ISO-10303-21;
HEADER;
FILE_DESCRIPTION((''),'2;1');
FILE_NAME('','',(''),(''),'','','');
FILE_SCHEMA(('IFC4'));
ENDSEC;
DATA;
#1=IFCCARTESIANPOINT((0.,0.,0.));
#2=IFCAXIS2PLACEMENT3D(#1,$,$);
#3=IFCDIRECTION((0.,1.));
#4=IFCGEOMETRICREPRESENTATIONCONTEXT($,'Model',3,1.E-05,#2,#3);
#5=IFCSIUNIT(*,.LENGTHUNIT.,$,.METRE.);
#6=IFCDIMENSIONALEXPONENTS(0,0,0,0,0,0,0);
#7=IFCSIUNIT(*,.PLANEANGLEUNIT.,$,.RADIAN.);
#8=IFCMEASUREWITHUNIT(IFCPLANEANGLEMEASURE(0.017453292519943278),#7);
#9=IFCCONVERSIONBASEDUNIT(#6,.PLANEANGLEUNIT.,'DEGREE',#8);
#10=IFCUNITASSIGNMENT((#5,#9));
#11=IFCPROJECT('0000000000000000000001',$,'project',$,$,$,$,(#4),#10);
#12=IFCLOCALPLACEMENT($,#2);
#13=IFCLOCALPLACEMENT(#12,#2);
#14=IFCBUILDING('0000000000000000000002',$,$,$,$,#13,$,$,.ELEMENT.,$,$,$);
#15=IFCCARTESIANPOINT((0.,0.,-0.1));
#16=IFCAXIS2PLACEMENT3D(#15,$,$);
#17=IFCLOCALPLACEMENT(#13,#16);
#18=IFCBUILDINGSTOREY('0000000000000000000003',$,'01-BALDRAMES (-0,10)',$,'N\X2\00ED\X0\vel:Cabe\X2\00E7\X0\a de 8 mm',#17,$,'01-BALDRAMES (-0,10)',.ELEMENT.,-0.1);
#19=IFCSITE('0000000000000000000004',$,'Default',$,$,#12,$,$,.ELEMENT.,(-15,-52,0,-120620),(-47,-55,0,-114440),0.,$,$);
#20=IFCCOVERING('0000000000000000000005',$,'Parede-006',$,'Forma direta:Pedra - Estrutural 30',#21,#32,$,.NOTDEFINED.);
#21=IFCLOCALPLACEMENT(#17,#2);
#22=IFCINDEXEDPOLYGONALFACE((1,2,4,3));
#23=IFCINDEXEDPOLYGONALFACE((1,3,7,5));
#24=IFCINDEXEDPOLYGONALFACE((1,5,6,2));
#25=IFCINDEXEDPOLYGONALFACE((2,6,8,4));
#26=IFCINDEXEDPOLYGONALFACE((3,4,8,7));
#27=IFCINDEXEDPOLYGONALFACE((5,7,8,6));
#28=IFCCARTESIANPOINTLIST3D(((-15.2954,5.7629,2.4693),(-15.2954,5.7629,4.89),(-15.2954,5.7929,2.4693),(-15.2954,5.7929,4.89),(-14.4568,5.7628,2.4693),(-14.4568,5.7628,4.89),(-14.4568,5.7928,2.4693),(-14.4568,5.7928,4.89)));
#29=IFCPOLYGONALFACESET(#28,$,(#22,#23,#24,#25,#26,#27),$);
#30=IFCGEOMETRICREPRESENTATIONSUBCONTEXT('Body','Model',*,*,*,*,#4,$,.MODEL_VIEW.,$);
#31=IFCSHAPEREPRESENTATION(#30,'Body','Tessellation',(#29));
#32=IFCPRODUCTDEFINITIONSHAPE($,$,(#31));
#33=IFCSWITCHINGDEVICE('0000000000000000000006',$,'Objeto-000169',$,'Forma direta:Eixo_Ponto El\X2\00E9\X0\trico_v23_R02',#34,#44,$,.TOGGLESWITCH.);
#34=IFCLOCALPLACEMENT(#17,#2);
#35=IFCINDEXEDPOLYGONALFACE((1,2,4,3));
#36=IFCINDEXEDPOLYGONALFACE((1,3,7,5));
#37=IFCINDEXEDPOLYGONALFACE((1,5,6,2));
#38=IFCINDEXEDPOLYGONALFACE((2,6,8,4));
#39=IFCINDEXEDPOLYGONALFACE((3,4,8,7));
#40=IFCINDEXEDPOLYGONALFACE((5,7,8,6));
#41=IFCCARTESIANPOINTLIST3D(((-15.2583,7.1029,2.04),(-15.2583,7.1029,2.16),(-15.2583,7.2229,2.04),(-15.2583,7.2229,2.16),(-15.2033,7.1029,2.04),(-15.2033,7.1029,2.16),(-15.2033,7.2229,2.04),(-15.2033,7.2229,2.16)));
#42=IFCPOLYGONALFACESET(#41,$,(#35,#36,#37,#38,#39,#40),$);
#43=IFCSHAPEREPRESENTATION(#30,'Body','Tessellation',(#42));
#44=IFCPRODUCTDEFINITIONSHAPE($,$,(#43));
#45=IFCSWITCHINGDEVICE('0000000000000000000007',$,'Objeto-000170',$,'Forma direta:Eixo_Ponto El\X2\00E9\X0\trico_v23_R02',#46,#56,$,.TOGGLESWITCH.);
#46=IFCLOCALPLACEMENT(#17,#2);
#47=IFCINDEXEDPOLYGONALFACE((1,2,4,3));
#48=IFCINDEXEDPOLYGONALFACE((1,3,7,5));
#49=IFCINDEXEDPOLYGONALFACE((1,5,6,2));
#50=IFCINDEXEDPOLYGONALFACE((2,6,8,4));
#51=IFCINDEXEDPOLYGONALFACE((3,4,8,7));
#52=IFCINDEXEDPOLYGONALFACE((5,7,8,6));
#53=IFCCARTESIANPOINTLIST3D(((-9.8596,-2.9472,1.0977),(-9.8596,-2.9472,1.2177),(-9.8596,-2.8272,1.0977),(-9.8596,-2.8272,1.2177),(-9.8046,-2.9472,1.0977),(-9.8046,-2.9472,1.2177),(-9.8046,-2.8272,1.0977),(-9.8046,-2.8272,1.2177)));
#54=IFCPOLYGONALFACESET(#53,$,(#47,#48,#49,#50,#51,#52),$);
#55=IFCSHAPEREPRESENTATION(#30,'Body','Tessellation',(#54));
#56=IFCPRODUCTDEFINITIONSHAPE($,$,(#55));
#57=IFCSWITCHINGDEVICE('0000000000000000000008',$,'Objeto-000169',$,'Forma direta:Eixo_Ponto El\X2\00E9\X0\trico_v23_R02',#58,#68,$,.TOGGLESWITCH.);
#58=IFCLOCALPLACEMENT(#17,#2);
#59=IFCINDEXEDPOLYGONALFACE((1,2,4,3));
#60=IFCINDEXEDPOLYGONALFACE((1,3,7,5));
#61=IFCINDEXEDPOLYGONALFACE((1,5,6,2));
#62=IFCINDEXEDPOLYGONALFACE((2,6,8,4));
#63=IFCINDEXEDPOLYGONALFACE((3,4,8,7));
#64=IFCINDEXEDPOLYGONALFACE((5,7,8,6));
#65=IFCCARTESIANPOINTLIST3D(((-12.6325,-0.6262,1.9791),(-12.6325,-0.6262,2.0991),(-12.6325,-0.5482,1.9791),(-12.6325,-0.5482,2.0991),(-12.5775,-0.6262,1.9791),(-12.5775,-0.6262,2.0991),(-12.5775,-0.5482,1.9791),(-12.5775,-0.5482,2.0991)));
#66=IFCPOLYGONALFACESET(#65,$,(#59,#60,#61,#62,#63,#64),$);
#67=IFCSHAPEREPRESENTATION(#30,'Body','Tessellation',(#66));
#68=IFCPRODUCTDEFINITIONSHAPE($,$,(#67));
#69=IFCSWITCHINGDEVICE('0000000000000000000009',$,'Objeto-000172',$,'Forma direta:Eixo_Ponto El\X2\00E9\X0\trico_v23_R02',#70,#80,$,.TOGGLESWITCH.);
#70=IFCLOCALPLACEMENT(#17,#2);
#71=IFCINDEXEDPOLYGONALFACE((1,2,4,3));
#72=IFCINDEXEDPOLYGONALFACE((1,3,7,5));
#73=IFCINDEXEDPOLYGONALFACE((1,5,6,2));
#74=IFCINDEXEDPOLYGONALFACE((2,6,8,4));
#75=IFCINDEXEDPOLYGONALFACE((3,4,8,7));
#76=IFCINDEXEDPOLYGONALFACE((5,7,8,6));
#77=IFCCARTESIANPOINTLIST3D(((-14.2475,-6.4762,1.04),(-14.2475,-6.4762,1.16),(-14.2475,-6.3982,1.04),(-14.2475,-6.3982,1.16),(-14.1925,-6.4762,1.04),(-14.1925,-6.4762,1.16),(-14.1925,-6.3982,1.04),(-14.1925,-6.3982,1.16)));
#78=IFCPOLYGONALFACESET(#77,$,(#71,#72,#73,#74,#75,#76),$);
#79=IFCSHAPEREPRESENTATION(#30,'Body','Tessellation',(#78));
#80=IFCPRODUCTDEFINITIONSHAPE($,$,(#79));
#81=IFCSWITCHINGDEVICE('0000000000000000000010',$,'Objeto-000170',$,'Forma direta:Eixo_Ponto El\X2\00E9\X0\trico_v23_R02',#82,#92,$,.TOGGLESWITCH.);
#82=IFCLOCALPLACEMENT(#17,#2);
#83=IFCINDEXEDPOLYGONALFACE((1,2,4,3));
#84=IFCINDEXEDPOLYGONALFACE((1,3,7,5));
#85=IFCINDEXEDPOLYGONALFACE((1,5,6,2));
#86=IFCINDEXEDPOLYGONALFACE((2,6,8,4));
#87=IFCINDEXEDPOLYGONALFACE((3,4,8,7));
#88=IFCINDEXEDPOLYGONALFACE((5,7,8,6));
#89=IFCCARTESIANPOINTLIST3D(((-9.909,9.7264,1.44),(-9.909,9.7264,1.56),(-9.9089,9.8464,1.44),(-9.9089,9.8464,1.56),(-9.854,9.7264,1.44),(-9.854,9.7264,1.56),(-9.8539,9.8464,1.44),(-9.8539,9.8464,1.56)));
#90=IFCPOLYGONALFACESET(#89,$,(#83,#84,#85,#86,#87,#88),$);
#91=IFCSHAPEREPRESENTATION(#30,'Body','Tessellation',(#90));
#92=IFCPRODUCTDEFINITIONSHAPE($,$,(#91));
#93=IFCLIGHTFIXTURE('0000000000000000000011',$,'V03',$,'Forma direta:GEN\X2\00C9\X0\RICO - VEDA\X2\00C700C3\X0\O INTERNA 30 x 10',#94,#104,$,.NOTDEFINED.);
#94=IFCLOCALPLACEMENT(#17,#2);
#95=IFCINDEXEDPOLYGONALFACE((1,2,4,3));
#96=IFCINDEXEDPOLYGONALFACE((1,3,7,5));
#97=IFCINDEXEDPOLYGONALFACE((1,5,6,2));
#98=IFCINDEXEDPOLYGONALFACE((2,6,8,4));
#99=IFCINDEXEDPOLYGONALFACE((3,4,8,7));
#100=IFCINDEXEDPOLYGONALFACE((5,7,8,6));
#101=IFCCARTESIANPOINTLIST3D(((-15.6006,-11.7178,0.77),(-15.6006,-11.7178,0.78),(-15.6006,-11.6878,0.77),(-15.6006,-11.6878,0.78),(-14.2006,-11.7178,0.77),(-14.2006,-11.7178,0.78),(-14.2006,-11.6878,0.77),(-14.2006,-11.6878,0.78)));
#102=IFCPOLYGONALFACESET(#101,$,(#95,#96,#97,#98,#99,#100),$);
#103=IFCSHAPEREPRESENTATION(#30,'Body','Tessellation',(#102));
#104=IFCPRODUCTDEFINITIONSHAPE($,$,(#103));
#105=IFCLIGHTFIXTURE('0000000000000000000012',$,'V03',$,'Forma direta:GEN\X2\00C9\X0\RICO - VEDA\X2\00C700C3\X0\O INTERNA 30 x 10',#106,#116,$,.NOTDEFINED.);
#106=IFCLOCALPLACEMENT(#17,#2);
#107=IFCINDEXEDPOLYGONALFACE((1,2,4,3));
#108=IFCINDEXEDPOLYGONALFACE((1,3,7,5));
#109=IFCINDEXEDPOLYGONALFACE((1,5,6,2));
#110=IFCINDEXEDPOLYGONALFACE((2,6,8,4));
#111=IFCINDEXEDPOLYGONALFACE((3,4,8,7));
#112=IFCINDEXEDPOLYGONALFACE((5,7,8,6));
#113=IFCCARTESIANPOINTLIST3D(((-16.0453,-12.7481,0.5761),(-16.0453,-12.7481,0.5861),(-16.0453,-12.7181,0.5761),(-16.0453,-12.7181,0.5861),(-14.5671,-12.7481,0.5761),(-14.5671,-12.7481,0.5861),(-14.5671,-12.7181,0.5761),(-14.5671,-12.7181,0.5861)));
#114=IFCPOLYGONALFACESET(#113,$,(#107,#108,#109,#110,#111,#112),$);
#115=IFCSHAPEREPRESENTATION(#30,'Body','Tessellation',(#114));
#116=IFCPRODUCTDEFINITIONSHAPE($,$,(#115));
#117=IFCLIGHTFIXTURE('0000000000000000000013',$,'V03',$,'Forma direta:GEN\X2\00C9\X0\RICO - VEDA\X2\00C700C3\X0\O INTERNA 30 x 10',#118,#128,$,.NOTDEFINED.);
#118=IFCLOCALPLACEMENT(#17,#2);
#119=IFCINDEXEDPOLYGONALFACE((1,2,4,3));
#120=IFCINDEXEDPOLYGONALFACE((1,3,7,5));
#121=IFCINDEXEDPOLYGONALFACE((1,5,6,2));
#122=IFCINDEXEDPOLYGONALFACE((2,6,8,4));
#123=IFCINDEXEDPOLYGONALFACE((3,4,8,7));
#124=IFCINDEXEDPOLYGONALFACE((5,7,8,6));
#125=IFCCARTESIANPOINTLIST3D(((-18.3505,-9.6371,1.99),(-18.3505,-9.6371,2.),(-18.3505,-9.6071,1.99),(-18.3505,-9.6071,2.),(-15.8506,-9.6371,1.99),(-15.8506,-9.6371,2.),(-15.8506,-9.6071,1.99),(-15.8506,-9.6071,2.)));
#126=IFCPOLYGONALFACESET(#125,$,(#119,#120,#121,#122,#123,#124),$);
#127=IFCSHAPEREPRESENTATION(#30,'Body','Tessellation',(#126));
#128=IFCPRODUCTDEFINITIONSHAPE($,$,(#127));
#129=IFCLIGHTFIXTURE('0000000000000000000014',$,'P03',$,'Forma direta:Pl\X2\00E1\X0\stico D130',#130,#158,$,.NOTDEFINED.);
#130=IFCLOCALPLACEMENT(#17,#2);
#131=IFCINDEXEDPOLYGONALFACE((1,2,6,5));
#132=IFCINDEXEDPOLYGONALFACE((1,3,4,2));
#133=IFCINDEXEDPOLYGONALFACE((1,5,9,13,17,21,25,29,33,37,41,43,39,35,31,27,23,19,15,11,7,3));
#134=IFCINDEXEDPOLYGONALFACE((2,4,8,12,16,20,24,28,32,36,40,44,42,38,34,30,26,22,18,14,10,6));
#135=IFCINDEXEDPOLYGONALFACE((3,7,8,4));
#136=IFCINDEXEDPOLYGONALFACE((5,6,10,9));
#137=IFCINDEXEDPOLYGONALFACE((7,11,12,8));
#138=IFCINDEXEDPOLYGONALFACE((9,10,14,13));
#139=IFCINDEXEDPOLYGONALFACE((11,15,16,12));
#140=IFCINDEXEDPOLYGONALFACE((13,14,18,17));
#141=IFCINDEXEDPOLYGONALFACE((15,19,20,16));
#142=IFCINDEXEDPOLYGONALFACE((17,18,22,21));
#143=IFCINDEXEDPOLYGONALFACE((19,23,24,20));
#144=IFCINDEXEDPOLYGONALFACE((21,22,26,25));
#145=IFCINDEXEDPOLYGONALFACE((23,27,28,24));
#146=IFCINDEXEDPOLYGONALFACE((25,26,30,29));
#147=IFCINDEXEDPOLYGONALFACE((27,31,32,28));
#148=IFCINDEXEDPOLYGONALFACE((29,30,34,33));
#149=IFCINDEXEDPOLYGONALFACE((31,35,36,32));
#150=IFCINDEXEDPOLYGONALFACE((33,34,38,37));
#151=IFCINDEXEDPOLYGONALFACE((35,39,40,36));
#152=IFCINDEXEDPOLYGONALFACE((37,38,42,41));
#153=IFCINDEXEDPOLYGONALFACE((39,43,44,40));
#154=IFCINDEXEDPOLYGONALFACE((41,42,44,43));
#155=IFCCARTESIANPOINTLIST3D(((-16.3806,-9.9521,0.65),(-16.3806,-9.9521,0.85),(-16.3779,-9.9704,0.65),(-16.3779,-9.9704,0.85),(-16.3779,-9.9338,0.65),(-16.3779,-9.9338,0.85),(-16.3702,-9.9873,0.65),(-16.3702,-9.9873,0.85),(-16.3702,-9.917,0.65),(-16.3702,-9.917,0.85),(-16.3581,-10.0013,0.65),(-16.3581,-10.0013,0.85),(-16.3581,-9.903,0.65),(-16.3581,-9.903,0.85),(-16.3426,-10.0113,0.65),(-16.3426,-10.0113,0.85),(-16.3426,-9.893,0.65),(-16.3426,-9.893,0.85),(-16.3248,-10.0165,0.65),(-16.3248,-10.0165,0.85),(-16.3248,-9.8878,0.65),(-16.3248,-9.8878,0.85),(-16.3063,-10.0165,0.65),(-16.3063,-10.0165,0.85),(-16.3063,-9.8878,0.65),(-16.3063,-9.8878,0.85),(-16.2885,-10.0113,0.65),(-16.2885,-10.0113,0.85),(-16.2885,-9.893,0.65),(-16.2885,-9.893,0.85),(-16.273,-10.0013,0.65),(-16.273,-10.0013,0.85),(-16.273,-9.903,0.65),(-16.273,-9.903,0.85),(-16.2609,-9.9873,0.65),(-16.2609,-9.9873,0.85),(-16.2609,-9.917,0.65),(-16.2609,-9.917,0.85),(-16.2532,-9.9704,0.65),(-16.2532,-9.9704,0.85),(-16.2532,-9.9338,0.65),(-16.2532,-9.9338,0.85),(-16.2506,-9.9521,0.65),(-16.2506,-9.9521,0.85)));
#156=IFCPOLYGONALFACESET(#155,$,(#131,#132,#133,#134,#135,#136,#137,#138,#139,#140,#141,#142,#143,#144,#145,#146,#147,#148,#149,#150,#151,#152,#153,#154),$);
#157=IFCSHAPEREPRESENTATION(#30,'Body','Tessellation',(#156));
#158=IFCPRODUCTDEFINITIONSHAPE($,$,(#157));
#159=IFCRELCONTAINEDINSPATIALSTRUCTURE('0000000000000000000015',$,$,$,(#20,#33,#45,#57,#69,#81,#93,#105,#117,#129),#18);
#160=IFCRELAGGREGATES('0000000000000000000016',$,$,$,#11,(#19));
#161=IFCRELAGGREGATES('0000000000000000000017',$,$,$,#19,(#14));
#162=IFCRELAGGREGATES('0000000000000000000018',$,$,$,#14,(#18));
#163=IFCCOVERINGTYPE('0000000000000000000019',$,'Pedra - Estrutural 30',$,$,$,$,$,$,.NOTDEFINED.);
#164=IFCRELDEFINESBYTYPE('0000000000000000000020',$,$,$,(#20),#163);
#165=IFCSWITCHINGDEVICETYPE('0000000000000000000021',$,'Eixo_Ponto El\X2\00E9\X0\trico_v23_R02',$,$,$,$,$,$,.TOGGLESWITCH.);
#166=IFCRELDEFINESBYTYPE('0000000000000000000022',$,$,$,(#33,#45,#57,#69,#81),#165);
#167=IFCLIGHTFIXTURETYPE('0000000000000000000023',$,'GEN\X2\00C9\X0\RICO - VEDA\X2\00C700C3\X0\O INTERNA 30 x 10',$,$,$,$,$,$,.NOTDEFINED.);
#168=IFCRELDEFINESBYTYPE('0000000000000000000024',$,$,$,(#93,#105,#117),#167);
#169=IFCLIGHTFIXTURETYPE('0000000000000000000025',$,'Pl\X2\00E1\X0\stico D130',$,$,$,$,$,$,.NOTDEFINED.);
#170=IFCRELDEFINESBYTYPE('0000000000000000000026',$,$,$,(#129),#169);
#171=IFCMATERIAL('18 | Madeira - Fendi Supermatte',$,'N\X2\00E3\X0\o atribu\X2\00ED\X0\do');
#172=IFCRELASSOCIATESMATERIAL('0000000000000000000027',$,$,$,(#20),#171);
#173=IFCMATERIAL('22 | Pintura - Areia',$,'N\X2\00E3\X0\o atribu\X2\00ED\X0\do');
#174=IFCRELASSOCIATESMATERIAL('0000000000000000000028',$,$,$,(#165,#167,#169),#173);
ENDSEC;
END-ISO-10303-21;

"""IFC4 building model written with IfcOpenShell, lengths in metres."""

from ifc_helpers import new_model, entity, si_unit, converted_unit, direction, frame, origin, place, context, subcontext, project, spatial, arc, indexed_curve, outline, extrude, material, type_object, element, save


model = new_model("IFC4")

# Units and contexts
model_context = context("Model", 3, precision=1e-05, world=origin(), true_north=direction((0.0, 1.0)))
body_context = subcontext(model_context, "Body", "Model", "MODEL_VIEW")
ifc_project = project(units=[si_unit("LENGTHUNIT", "METRE"), converted_unit("PLANEANGLEUNIT", "DEGREE", entity("IfcPlaneAngleMeasure", 0.017453292519943278), si_unit("PLANEANGLEUNIT", "RADIAN"), dimensions=[0, 0, 0, 0, 0, 0, 0])], contexts=[model_context])

# Site, building, storey
site_placement = place(None, origin())
site = spatial("IfcSite", under=ifc_project, at=site_placement, Name="Default", CompositionType="ELEMENT", RefLatitude=(-15, -52, 0, -120620), RefLongitude=(-47, -55, 0, -114440), RefElevation=0.0)
building_placement = place(site_placement, origin())
building = spatial("IfcBuilding", under=site, at=building_placement, CompositionType="ELEMENT")
storey_placement = place(building_placement, frame((0.0, 0.0, -0.1)))
storey = spatial("IfcBuildingStorey", under=building, at=storey_placement, Name="01-BALDRAMES (-0,10)", ObjectType="Nível:Cabeça de 8 mm", LongName="01-BALDRAMES (-0,10)", CompositionType="ELEMENT", Elevation=-0.1)

# Covering
ifc_material_1 = material(Name="18 | Madeira - Fendi Supermatte", Category="Não atribuído")
covering_type = type_object("IfcCoveringType", Name="Pedra - Estrutural 30", PredefinedType="NOTDEFINED")
covering_placement = place(storey_placement, origin())
element("IfcCovering", 1, at=covering_placement, inside=storey, type_object=covering_type, material=ifc_material_1, Name="Parede-006", ObjectType="Forma direta:Pedra - Estrutural 30", PredefinedType="NOTDEFINED", context=body_context, shape_type="SweptSolid", body=[
    extrude(outline(indexed_curve([(-0.015, -0.4193), (0.015, -0.4193), (0.015, 0.4193), (-0.015, 0.4193), (-0.015, -0.4193)], self_intersect=False)), frame((-14.8761, 5.7778, 2.4693), z_axis=(0.0, 0.0, 1.0), x_axis=(0.000013, 1.0, 0.0)), (0.0, 0.0, 1.0), 2.4207),
])

# Switching devices
ifc_material_2 = material(Name="22 | Pintura - Areia", Category="Não atribuído")
switching_device_type = type_object("IfcSwitchingDeviceType", Name="Eixo_Ponto Elétrico_v23_R02", PredefinedType="TOGGLESWITCH", material=ifc_material_2)
switching_device_1_placement = place(storey_placement, origin())
element("IfcSwitchingDevice", 2, at=switching_device_1_placement, inside=storey, type_object=switching_device_type, Name="Objeto-000169", ObjectType="Forma direta:Eixo_Ponto Elétrico_v23_R02", PredefinedType="TOGGLESWITCH", context=body_context, shape_type="SweptSolid", body=[
    extrude(outline(indexed_curve([(-0.0275, -0.06), (0.0275, -0.06), (0.0275, 0.06), (-0.0275, 0.06), (-0.0275, -0.06)], self_intersect=False)), frame((-15.2308, 7.1629, 2.04)), (0.0, 0.0, 1.0), 0.12),
])
switching_device_2_placement = place(storey_placement, origin())
element("IfcSwitchingDevice", 3, at=switching_device_2_placement, inside=storey, type_object=switching_device_type, Name="Objeto-000170", ObjectType="Forma direta:Eixo_Ponto Elétrico_v23_R02", PredefinedType="TOGGLESWITCH", context=body_context, shape_type="SweptSolid", body=[
    extrude(outline(indexed_curve([(-0.0275, -0.06), (0.0275, -0.06), (0.0275, 0.06), (-0.0275, 0.06), (-0.0275, -0.06)], self_intersect=False)), frame((-9.8321, -2.8872, 1.0977)), (0.0, 0.0, 1.0), 0.12),
])
switching_device_3_placement = place(storey_placement, origin())
element("IfcSwitchingDevice", 4, at=switching_device_3_placement, inside=storey, type_object=switching_device_type, Name="Objeto-000169", ObjectType="Forma direta:Eixo_Ponto Elétrico_v23_R02", PredefinedType="TOGGLESWITCH", context=body_context, shape_type="SweptSolid", body=[
    extrude(outline(indexed_curve([(-0.0275, -0.039), (0.0275, -0.039), (0.0275, 0.039), (-0.0275, 0.039), (-0.0275, -0.039)], self_intersect=False)), frame((-12.605, -0.5872, 1.9791), z_axis=(0.0, 0.0, 1.0), x_axis=(-1.0, 0.000046, 0.0)), (0.0, 0.0, 1.0), 0.12),
])
switching_device_4_placement = place(storey_placement, origin())
element("IfcSwitchingDevice", 5, at=switching_device_4_placement, inside=storey, type_object=switching_device_type, Name="Objeto-000172", ObjectType="Forma direta:Eixo_Ponto Elétrico_v23_R02", PredefinedType="TOGGLESWITCH", context=body_context, shape_type="SweptSolid", body=[
    extrude(outline(indexed_curve([(-0.0275, -0.039), (0.0275, -0.039), (0.0275, 0.039), (-0.0275, 0.039), (-0.0275, -0.039)], self_intersect=False)), frame((-14.22, -6.4372, 1.04), z_axis=(0.0, 0.0, 1.0), x_axis=(-1.0, -0.000186, 0.0)), (0.0, 0.0, 1.0), 0.12),
])
switching_device_5_placement = place(storey_placement, origin())
element("IfcSwitchingDevice", 6, at=switching_device_5_placement, inside=storey, type_object=switching_device_type, Name="Objeto-000170", ObjectType="Forma direta:Eixo_Ponto Elétrico_v23_R02", PredefinedType="TOGGLESWITCH", context=body_context, shape_type="SweptSolid", body=[
    extrude(outline(indexed_curve([(-0.0275, -0.06), (0.0275, -0.06), (0.0275, 0.06), (-0.0275, 0.06), (-0.0275, -0.06)], self_intersect=False)), frame((-9.8815, 9.7864, 1.44), z_axis=(0.0, 0.0, 1.0), x_axis=(1.0, -0.000744, 0.0)), (0.0, 0.0, 1.0), 0.12),
])

# Light fixtures
light_fixture_type_1 = type_object("IfcLightFixtureType", Name="GENÉRICO - VEDAÇÃO INTERNA 30 x 10", PredefinedType="NOTDEFINED", material=ifc_material_2)
light_fixture_1_placement = place(storey_placement, origin())
element("IfcLightFixture", 7, at=light_fixture_1_placement, inside=storey, type_object=light_fixture_type_1, Name="V03", ObjectType="Forma direta:GENÉRICO - VEDAÇÃO INTERNA 30 x 10", PredefinedType="NOTDEFINED", context=body_context, shape_type="SweptSolid", body=[
    extrude(outline(indexed_curve([(-0.7, -0.015), (0.7, -0.015), (0.7, 0.015), (-0.7, 0.015), (-0.7, -0.015)], self_intersect=False)), frame((-14.9006, -11.7028, 0.77)), (0.0, 0.0, 1.0), 0.01),
])
light_fixture_2_placement = place(storey_placement, origin())
element("IfcLightFixture", 8, at=light_fixture_2_placement, inside=storey, type_object=light_fixture_type_1, Name="V03", ObjectType="Forma direta:GENÉRICO - VEDAÇÃO INTERNA 30 x 10", PredefinedType="NOTDEFINED", context=body_context, shape_type="SweptSolid", body=[
    extrude(outline(indexed_curve([(-0.7391, -0.015), (0.7391, -0.015), (0.7391, 0.015), (-0.7391, 0.015), (-0.7391, -0.015)], self_intersect=False)), frame((-15.3062, -12.7331, 0.5761)), (0.0, 0.0, 1.0), 0.01),
])
light_fixture_3_placement = place(storey_placement, origin())
element("IfcLightFixture", 9, at=light_fixture_3_placement, inside=storey, type_object=light_fixture_type_1, Name="V03", ObjectType="Forma direta:GENÉRICO - VEDAÇÃO INTERNA 30 x 10", PredefinedType="NOTDEFINED", context=body_context, shape_type="SweptSolid", body=[
    extrude(outline(indexed_curve([(-1.25, -0.015), (1.25, -0.015), (1.25, 0.015), (-1.25, 0.015), (-1.25, -0.015)], self_intersect=False)), frame((-17.1005, -9.6221, 1.99)), (0.0, 0.0, 1.0), 0.01),
])
light_fixture_type_2 = type_object("IfcLightFixtureType", Name="Plástico D130", PredefinedType="NOTDEFINED", material=ifc_material_2)
light_fixture_4_placement = place(storey_placement, origin())
element("IfcLightFixture", 10, at=light_fixture_4_placement, inside=storey, type_object=light_fixture_type_2, Name="P03", ObjectType="Forma direta:Plástico D130", PredefinedType="NOTDEFINED", context=body_context, shape_type="SweptSolid", body=[
    extrude(outline(indexed_curve([(0.065, 0.0), (0.0, 0.065), (-0.065, 0.0), (0.0, -0.065)], segments=[arc(1, 2, 3), arc(3, 4, 1)], self_intersect=False)), frame((-16.3156, -9.9521, 0.65)), (0.0, 0.0, 1.0), 0.2),
])

save(model, "model.ifc")
